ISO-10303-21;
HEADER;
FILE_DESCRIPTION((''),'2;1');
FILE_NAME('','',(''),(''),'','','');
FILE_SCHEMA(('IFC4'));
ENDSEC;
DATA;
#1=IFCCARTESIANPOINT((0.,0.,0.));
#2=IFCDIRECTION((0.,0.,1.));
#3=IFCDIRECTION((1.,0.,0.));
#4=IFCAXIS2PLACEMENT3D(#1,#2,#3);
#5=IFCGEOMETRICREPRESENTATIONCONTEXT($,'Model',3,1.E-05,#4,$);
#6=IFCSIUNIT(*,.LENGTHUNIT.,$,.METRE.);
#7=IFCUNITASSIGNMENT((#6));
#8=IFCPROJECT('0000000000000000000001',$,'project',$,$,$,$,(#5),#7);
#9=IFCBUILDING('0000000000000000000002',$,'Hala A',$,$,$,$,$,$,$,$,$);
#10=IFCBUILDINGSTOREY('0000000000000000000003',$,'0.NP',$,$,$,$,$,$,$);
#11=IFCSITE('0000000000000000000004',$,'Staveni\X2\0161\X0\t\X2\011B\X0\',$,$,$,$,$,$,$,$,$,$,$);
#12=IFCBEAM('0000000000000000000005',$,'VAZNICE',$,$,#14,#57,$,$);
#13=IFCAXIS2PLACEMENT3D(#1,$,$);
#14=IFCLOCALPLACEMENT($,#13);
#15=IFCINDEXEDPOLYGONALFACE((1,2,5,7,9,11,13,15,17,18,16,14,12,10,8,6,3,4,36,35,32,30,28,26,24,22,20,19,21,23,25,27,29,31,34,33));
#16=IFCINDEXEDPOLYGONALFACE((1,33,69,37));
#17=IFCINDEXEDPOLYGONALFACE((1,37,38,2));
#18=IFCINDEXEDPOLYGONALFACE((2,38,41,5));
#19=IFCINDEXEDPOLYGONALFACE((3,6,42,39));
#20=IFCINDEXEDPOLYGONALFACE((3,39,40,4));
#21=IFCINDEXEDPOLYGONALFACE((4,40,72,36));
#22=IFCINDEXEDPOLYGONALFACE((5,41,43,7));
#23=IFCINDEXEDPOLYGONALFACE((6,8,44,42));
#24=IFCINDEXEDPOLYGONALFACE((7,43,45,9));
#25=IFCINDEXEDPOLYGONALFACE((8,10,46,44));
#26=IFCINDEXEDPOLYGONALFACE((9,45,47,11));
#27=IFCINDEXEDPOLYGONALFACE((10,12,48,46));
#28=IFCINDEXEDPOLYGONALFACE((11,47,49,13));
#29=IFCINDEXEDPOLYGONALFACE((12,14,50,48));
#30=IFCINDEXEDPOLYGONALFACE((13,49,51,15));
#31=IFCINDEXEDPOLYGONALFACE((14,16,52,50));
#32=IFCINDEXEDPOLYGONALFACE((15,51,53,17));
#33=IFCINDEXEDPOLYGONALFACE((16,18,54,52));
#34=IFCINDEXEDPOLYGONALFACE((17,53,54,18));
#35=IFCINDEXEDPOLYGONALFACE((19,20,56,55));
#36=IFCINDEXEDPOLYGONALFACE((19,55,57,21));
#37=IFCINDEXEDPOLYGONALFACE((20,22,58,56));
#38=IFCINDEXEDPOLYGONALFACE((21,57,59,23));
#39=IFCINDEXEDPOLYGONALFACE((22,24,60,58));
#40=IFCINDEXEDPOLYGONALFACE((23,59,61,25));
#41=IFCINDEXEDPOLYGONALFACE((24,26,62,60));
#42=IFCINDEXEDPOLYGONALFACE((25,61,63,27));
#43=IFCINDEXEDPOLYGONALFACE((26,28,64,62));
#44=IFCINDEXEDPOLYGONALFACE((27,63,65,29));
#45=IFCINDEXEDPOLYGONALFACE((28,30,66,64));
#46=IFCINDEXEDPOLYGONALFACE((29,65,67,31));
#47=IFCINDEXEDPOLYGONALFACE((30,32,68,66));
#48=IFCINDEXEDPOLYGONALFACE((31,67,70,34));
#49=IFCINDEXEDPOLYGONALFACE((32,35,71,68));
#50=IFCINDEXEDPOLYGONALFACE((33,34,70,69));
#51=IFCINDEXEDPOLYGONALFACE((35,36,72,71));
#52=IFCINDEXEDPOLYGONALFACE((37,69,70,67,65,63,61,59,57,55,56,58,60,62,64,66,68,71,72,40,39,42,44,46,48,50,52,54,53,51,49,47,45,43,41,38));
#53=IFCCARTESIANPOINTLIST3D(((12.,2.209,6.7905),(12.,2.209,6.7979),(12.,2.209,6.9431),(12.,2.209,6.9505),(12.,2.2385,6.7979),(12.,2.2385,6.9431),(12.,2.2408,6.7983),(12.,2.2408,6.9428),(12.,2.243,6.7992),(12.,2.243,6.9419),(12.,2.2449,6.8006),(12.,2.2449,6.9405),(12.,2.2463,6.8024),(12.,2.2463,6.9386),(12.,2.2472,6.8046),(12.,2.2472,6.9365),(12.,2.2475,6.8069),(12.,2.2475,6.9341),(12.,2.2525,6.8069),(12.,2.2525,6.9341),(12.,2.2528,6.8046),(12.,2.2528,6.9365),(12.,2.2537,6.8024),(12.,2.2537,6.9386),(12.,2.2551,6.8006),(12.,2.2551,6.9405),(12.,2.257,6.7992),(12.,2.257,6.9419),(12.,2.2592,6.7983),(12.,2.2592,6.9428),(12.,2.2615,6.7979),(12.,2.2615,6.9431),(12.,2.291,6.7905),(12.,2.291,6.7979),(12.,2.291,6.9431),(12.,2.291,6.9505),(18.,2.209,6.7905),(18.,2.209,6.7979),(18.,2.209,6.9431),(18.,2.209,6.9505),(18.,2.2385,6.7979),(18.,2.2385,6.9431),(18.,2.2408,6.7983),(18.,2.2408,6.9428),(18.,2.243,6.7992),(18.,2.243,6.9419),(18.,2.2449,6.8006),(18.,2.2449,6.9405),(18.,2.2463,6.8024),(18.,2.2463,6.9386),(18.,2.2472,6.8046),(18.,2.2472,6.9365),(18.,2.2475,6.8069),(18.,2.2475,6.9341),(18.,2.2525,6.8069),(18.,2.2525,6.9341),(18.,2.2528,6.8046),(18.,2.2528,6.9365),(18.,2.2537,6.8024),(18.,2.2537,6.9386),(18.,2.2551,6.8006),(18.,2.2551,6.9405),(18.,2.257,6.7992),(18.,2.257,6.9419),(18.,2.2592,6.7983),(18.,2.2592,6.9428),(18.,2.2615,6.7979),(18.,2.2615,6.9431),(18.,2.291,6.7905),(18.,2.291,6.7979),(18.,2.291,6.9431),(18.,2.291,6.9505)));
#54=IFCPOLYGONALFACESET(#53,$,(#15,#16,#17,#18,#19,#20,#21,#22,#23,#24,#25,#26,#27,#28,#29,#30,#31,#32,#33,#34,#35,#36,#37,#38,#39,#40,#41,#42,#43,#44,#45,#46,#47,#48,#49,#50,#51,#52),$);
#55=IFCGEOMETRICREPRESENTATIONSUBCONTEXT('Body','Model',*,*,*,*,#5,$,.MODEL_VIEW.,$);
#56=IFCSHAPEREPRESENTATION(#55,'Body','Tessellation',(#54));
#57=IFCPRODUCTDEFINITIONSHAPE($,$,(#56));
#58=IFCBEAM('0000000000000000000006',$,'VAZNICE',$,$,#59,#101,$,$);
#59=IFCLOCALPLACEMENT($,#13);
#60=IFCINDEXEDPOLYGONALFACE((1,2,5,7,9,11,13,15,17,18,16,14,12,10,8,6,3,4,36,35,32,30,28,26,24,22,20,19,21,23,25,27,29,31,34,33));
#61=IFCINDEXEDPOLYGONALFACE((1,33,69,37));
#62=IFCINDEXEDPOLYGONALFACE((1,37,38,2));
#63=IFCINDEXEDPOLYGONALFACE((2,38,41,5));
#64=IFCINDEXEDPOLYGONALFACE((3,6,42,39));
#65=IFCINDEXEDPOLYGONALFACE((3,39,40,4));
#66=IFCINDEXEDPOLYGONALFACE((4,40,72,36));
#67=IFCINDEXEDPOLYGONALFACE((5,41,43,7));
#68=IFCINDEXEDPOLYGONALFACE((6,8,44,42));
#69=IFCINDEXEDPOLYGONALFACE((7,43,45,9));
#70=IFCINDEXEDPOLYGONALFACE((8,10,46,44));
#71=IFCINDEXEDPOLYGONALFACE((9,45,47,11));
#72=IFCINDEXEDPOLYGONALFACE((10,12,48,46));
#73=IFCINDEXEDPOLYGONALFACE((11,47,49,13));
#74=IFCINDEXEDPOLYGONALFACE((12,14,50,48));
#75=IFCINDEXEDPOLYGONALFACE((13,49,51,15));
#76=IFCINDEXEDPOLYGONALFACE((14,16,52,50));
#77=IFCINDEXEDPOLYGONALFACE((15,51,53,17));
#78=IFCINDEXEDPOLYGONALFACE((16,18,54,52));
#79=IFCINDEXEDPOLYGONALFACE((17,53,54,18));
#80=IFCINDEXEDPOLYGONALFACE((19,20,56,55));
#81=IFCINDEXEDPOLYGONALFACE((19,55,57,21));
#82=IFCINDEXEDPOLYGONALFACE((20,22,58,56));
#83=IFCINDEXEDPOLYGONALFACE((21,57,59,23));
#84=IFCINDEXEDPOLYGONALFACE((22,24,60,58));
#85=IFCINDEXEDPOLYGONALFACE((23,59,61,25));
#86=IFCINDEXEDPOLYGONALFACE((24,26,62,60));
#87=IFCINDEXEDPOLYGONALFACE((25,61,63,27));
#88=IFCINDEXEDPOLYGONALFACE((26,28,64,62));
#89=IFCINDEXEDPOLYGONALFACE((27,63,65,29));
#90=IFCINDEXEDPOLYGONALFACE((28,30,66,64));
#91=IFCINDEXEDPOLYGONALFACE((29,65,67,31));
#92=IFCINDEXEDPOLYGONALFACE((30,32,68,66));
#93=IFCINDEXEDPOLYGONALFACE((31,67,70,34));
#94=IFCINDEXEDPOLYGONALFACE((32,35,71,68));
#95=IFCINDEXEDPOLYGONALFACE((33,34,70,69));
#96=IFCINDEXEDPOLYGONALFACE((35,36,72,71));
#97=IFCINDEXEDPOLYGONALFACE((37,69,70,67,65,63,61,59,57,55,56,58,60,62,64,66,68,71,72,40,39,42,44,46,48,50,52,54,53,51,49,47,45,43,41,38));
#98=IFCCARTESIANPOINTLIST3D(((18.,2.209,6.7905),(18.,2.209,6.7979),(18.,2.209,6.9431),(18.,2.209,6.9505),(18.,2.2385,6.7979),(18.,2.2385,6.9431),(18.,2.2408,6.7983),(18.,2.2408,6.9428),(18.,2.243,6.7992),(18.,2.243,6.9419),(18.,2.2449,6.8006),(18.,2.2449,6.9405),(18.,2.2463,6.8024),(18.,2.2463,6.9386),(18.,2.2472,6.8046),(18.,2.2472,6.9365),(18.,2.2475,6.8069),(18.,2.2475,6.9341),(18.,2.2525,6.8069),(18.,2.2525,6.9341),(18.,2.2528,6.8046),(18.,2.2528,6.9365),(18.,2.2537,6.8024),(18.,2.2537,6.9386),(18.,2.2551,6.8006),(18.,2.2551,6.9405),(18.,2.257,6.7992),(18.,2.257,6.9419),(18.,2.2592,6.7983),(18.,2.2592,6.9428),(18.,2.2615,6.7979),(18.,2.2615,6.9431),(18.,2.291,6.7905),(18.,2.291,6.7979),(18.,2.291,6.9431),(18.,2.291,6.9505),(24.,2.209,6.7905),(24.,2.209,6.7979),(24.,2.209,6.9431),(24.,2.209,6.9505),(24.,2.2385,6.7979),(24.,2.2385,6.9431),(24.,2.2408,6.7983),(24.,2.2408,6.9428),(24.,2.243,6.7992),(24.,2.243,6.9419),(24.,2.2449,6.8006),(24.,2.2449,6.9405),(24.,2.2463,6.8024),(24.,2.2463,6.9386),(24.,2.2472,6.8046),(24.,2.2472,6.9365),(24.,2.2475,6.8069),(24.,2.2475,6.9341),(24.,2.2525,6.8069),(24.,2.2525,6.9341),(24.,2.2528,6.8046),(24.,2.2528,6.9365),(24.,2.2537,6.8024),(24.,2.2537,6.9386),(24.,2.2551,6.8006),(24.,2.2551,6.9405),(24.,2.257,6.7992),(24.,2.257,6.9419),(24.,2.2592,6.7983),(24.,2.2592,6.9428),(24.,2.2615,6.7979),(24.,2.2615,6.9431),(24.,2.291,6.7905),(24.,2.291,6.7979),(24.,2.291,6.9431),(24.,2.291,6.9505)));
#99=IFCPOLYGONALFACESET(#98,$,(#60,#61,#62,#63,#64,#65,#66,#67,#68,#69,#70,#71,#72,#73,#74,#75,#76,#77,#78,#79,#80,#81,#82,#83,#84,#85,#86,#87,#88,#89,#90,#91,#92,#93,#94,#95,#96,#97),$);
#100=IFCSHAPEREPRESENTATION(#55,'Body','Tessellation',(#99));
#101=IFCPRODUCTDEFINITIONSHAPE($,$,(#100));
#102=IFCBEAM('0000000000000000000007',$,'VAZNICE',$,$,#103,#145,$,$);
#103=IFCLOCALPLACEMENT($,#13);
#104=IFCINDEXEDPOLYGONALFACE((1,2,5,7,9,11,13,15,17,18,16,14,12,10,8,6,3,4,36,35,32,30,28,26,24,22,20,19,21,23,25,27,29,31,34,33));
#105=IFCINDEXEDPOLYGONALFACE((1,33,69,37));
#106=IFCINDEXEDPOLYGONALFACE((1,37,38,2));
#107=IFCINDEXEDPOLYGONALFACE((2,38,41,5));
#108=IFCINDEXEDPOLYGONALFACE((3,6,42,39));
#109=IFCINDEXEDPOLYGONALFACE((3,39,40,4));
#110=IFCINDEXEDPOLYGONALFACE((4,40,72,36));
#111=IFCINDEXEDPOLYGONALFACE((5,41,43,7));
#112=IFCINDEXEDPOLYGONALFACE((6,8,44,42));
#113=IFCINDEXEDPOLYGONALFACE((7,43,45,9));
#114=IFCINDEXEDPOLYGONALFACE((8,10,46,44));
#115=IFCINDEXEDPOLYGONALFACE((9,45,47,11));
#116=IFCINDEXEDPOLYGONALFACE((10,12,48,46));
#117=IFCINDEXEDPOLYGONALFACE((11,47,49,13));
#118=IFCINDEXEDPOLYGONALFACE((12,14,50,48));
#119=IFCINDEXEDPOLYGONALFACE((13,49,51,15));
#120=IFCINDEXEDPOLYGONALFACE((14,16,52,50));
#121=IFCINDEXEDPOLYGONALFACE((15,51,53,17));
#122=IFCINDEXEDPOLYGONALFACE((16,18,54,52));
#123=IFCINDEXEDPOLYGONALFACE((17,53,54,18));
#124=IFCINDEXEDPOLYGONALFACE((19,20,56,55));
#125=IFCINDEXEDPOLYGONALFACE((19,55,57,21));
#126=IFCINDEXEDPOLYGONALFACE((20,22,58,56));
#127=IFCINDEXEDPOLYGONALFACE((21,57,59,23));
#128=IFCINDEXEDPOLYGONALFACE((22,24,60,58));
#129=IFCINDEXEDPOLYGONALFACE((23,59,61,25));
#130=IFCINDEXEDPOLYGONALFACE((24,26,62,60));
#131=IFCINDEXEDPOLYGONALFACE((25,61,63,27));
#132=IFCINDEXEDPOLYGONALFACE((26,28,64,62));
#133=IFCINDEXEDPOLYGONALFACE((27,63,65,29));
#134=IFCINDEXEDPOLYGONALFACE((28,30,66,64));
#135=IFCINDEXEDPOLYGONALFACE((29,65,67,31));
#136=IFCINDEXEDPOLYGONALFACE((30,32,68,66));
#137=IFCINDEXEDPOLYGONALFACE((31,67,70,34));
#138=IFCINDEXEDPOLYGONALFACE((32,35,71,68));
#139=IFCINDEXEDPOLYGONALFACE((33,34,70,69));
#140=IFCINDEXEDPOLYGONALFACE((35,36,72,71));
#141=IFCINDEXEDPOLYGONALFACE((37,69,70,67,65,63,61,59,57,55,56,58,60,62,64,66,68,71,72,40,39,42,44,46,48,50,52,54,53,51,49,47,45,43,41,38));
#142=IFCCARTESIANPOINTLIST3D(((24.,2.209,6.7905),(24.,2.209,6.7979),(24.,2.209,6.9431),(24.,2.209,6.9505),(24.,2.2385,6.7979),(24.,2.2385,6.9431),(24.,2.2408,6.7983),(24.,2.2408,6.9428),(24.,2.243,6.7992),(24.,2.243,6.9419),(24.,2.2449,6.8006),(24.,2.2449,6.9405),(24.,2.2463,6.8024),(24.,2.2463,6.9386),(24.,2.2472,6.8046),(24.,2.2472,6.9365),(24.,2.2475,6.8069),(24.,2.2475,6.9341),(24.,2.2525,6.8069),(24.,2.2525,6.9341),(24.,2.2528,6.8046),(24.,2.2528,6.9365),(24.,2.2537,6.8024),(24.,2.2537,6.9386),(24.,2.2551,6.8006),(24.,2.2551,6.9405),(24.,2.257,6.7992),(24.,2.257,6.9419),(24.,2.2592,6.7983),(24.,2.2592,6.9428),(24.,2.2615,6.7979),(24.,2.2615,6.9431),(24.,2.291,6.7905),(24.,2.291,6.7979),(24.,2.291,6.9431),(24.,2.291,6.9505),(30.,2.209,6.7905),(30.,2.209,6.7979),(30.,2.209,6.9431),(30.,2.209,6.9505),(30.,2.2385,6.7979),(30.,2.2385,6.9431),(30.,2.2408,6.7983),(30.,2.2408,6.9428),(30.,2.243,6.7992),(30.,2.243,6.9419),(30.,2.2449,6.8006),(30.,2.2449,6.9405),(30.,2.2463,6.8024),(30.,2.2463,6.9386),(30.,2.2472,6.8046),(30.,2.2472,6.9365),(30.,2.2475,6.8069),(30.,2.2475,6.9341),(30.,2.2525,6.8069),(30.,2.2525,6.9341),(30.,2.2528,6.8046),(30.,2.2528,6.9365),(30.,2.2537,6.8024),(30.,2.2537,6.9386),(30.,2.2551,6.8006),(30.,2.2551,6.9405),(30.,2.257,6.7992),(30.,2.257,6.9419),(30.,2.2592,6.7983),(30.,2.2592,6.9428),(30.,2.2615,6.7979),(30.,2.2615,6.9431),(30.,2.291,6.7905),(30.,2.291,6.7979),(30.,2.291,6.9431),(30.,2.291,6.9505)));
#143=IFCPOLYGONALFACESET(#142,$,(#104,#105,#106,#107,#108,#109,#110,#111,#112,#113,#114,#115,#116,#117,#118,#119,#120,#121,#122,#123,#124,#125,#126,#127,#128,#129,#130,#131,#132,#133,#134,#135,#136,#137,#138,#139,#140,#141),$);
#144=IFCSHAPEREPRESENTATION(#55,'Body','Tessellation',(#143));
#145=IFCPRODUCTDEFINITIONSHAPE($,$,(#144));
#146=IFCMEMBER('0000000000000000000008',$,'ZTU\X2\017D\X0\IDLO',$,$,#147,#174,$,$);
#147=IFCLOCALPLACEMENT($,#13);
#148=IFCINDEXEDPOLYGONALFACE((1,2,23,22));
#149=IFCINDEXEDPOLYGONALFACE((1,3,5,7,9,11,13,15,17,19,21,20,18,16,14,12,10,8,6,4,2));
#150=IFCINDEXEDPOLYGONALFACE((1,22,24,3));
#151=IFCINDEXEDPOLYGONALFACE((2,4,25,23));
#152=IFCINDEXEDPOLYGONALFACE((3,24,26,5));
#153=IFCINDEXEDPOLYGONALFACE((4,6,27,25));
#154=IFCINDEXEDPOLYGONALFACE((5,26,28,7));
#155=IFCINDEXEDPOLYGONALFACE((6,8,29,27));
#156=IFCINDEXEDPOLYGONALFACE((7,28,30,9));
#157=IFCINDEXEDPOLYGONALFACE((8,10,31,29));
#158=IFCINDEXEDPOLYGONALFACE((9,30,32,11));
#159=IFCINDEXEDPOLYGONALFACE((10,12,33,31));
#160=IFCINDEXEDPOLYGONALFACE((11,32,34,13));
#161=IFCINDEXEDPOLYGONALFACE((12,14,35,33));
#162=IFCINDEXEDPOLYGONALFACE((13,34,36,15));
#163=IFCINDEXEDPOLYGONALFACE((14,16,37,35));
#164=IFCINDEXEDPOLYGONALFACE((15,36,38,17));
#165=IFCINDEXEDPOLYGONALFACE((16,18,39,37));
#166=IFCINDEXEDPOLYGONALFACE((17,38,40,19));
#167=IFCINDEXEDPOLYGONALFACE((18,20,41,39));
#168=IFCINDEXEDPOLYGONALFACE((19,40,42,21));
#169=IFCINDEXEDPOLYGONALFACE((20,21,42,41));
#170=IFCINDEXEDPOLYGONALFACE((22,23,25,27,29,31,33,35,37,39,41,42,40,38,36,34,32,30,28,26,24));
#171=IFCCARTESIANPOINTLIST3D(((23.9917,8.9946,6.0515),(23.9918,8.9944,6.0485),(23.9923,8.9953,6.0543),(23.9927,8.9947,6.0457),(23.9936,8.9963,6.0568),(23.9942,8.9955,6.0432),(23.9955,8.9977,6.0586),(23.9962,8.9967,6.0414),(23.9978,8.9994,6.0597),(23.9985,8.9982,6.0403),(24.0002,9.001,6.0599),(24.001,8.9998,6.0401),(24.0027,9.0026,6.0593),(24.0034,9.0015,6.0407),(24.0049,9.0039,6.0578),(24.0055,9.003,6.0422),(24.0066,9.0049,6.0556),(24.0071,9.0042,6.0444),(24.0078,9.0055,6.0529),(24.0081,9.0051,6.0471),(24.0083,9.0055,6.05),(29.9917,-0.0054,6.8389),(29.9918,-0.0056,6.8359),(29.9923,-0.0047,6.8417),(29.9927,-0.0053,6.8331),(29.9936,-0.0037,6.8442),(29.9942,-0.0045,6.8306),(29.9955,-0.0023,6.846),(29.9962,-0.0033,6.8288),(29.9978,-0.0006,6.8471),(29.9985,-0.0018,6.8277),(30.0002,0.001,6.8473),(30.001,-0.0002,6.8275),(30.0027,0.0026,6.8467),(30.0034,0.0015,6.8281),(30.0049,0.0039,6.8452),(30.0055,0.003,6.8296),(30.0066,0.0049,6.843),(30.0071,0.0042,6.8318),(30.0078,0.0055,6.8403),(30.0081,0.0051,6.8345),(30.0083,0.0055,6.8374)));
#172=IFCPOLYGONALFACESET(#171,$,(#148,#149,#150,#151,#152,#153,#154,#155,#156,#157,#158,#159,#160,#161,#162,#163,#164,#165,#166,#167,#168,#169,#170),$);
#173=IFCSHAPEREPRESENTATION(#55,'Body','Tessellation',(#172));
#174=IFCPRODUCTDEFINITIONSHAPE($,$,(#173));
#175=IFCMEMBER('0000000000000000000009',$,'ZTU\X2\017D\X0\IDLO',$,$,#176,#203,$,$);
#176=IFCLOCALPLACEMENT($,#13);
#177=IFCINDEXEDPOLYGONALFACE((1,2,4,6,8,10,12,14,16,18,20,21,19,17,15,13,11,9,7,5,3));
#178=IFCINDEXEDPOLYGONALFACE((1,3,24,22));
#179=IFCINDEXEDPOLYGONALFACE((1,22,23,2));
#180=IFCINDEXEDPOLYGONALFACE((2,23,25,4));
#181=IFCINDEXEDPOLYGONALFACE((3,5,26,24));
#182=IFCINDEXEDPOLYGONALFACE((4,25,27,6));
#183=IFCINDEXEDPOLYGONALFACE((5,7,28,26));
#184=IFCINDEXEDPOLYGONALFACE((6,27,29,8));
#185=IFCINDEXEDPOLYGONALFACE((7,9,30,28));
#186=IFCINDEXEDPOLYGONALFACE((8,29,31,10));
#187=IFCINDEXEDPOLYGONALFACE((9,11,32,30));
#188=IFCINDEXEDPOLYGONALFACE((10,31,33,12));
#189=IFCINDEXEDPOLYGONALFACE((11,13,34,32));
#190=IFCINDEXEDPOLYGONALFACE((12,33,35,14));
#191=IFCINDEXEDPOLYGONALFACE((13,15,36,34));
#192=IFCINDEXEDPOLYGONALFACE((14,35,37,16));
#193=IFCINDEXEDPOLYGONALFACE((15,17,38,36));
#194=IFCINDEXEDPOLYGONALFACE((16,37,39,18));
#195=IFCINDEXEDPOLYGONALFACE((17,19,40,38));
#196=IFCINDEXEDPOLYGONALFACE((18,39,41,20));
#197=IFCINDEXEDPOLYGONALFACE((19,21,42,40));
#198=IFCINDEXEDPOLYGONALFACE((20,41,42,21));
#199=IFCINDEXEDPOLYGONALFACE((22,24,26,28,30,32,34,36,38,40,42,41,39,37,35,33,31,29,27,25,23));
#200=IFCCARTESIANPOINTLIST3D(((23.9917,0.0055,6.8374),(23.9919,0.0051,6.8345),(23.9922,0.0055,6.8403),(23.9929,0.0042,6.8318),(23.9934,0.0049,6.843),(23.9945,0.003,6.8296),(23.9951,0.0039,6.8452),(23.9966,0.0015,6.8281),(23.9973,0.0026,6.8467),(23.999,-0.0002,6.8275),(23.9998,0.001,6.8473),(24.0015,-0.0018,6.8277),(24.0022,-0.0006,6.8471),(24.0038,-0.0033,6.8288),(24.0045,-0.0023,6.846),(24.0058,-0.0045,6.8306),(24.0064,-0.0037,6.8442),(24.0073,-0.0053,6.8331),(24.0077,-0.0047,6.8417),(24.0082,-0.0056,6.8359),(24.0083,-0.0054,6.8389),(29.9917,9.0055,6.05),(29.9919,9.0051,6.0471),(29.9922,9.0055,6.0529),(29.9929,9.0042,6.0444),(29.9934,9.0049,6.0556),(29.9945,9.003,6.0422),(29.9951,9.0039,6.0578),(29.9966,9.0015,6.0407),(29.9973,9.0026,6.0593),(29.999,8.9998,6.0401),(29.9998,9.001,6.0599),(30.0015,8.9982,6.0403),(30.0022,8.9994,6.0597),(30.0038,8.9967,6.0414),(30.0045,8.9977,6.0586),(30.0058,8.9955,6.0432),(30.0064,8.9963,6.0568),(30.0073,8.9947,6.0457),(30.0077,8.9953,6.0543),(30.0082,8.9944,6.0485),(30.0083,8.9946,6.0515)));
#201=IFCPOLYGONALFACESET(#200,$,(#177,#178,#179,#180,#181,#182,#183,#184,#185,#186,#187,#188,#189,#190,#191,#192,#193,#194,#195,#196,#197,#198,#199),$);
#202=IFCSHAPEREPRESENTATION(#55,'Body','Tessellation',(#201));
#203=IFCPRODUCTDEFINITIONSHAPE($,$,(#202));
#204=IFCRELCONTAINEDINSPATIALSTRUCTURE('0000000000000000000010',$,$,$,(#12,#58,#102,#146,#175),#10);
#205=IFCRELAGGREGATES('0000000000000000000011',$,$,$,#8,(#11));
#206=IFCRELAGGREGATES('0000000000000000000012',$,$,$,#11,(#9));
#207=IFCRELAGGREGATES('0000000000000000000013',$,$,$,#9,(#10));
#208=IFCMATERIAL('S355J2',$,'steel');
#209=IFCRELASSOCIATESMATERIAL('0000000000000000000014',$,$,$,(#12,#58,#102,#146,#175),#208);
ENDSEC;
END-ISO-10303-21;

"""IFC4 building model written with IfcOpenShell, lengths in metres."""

from ifc_helpers import new_model, si_unit, frame, origin_with_axes, place, context, subcontext, project, spatial, circle, i_section, extrude, material, element, save


model = new_model("IFC4")

# Units and contexts
model_context = context("Model", 3, precision=1e-05, world=origin_with_axes())
body_context = subcontext(model_context, "Body", "Model", "MODEL_VIEW")
ifc_project = project(units=[si_unit("LENGTHUNIT", "METRE")], contexts=[model_context])

# Site, building, storey
site = spatial("IfcSite", under=ifc_project, Name="Staveniště")
building = spatial("IfcBuilding", under=site, Name="Hala A")
storey = spatial("IfcBuildingStorey", under=building, Name="0.NP")

# Shared definitions
ifc_material_1 = material(Name="S355J2", Category="steel")

# Beams
for number, where, z_axis, x_axis, name in (
    (1, (12.0, 2.25, 6.8705), (1.0, 0.0, 0.0), (0.0, 1.0, 0.0), "VAZNICE"),
    (2, (18.0, 2.25, 6.8705), (1.0, 0.0, 0.0), (0.0, 1.0, 0.0), "VAZNICE"),
    (3, (24.0, 2.25, 6.8705), (1.0, 0.0, 0.0), (0.0, 1.0, 0.0), "VAZNICE"),
):
    element("IfcBeam", number, at=place(None, frame(where, z_axis=z_axis, x_axis=x_axis)), inside=storey, material=ifc_material_1, Name=name, context=body_context, shape_type="SweptSolid", body=[
        extrude(i_section(OverallWidth=0.082, OverallDepth=0.16, WebThickness=0.005, FlangeThickness=0.0074, FilletRadius=0.009), origin_with_axes(), (0.0, 0.0, 1.0), 6.0),
    ])

# Members
for number, where, z_axis, x_axis, name in (
    (4, (24.0, 9.0, 6.05), (0.553236, -0.829854, 0.072603), (0.83205, 0.5547, 0.0), "ZTUŽIDLO"),
    (5, (24.0, 0.0, 6.8374), (0.553236, 0.829854, -0.072603), (-0.83205, 0.5547, 0.0), "ZTUŽIDLO"),
):
    element("IfcMember", number, at=place(None, frame(where, z_axis=z_axis, x_axis=x_axis)), inside=storey, material=ifc_material_1, Name=name, context=body_context, shape_type="SweptSolid", body=[
        extrude(circle(Radius=0.01), origin_with_axes(), (0.0, 0.0, 1.0), 10.8453),
    ])

save(model, "model.ifc")
